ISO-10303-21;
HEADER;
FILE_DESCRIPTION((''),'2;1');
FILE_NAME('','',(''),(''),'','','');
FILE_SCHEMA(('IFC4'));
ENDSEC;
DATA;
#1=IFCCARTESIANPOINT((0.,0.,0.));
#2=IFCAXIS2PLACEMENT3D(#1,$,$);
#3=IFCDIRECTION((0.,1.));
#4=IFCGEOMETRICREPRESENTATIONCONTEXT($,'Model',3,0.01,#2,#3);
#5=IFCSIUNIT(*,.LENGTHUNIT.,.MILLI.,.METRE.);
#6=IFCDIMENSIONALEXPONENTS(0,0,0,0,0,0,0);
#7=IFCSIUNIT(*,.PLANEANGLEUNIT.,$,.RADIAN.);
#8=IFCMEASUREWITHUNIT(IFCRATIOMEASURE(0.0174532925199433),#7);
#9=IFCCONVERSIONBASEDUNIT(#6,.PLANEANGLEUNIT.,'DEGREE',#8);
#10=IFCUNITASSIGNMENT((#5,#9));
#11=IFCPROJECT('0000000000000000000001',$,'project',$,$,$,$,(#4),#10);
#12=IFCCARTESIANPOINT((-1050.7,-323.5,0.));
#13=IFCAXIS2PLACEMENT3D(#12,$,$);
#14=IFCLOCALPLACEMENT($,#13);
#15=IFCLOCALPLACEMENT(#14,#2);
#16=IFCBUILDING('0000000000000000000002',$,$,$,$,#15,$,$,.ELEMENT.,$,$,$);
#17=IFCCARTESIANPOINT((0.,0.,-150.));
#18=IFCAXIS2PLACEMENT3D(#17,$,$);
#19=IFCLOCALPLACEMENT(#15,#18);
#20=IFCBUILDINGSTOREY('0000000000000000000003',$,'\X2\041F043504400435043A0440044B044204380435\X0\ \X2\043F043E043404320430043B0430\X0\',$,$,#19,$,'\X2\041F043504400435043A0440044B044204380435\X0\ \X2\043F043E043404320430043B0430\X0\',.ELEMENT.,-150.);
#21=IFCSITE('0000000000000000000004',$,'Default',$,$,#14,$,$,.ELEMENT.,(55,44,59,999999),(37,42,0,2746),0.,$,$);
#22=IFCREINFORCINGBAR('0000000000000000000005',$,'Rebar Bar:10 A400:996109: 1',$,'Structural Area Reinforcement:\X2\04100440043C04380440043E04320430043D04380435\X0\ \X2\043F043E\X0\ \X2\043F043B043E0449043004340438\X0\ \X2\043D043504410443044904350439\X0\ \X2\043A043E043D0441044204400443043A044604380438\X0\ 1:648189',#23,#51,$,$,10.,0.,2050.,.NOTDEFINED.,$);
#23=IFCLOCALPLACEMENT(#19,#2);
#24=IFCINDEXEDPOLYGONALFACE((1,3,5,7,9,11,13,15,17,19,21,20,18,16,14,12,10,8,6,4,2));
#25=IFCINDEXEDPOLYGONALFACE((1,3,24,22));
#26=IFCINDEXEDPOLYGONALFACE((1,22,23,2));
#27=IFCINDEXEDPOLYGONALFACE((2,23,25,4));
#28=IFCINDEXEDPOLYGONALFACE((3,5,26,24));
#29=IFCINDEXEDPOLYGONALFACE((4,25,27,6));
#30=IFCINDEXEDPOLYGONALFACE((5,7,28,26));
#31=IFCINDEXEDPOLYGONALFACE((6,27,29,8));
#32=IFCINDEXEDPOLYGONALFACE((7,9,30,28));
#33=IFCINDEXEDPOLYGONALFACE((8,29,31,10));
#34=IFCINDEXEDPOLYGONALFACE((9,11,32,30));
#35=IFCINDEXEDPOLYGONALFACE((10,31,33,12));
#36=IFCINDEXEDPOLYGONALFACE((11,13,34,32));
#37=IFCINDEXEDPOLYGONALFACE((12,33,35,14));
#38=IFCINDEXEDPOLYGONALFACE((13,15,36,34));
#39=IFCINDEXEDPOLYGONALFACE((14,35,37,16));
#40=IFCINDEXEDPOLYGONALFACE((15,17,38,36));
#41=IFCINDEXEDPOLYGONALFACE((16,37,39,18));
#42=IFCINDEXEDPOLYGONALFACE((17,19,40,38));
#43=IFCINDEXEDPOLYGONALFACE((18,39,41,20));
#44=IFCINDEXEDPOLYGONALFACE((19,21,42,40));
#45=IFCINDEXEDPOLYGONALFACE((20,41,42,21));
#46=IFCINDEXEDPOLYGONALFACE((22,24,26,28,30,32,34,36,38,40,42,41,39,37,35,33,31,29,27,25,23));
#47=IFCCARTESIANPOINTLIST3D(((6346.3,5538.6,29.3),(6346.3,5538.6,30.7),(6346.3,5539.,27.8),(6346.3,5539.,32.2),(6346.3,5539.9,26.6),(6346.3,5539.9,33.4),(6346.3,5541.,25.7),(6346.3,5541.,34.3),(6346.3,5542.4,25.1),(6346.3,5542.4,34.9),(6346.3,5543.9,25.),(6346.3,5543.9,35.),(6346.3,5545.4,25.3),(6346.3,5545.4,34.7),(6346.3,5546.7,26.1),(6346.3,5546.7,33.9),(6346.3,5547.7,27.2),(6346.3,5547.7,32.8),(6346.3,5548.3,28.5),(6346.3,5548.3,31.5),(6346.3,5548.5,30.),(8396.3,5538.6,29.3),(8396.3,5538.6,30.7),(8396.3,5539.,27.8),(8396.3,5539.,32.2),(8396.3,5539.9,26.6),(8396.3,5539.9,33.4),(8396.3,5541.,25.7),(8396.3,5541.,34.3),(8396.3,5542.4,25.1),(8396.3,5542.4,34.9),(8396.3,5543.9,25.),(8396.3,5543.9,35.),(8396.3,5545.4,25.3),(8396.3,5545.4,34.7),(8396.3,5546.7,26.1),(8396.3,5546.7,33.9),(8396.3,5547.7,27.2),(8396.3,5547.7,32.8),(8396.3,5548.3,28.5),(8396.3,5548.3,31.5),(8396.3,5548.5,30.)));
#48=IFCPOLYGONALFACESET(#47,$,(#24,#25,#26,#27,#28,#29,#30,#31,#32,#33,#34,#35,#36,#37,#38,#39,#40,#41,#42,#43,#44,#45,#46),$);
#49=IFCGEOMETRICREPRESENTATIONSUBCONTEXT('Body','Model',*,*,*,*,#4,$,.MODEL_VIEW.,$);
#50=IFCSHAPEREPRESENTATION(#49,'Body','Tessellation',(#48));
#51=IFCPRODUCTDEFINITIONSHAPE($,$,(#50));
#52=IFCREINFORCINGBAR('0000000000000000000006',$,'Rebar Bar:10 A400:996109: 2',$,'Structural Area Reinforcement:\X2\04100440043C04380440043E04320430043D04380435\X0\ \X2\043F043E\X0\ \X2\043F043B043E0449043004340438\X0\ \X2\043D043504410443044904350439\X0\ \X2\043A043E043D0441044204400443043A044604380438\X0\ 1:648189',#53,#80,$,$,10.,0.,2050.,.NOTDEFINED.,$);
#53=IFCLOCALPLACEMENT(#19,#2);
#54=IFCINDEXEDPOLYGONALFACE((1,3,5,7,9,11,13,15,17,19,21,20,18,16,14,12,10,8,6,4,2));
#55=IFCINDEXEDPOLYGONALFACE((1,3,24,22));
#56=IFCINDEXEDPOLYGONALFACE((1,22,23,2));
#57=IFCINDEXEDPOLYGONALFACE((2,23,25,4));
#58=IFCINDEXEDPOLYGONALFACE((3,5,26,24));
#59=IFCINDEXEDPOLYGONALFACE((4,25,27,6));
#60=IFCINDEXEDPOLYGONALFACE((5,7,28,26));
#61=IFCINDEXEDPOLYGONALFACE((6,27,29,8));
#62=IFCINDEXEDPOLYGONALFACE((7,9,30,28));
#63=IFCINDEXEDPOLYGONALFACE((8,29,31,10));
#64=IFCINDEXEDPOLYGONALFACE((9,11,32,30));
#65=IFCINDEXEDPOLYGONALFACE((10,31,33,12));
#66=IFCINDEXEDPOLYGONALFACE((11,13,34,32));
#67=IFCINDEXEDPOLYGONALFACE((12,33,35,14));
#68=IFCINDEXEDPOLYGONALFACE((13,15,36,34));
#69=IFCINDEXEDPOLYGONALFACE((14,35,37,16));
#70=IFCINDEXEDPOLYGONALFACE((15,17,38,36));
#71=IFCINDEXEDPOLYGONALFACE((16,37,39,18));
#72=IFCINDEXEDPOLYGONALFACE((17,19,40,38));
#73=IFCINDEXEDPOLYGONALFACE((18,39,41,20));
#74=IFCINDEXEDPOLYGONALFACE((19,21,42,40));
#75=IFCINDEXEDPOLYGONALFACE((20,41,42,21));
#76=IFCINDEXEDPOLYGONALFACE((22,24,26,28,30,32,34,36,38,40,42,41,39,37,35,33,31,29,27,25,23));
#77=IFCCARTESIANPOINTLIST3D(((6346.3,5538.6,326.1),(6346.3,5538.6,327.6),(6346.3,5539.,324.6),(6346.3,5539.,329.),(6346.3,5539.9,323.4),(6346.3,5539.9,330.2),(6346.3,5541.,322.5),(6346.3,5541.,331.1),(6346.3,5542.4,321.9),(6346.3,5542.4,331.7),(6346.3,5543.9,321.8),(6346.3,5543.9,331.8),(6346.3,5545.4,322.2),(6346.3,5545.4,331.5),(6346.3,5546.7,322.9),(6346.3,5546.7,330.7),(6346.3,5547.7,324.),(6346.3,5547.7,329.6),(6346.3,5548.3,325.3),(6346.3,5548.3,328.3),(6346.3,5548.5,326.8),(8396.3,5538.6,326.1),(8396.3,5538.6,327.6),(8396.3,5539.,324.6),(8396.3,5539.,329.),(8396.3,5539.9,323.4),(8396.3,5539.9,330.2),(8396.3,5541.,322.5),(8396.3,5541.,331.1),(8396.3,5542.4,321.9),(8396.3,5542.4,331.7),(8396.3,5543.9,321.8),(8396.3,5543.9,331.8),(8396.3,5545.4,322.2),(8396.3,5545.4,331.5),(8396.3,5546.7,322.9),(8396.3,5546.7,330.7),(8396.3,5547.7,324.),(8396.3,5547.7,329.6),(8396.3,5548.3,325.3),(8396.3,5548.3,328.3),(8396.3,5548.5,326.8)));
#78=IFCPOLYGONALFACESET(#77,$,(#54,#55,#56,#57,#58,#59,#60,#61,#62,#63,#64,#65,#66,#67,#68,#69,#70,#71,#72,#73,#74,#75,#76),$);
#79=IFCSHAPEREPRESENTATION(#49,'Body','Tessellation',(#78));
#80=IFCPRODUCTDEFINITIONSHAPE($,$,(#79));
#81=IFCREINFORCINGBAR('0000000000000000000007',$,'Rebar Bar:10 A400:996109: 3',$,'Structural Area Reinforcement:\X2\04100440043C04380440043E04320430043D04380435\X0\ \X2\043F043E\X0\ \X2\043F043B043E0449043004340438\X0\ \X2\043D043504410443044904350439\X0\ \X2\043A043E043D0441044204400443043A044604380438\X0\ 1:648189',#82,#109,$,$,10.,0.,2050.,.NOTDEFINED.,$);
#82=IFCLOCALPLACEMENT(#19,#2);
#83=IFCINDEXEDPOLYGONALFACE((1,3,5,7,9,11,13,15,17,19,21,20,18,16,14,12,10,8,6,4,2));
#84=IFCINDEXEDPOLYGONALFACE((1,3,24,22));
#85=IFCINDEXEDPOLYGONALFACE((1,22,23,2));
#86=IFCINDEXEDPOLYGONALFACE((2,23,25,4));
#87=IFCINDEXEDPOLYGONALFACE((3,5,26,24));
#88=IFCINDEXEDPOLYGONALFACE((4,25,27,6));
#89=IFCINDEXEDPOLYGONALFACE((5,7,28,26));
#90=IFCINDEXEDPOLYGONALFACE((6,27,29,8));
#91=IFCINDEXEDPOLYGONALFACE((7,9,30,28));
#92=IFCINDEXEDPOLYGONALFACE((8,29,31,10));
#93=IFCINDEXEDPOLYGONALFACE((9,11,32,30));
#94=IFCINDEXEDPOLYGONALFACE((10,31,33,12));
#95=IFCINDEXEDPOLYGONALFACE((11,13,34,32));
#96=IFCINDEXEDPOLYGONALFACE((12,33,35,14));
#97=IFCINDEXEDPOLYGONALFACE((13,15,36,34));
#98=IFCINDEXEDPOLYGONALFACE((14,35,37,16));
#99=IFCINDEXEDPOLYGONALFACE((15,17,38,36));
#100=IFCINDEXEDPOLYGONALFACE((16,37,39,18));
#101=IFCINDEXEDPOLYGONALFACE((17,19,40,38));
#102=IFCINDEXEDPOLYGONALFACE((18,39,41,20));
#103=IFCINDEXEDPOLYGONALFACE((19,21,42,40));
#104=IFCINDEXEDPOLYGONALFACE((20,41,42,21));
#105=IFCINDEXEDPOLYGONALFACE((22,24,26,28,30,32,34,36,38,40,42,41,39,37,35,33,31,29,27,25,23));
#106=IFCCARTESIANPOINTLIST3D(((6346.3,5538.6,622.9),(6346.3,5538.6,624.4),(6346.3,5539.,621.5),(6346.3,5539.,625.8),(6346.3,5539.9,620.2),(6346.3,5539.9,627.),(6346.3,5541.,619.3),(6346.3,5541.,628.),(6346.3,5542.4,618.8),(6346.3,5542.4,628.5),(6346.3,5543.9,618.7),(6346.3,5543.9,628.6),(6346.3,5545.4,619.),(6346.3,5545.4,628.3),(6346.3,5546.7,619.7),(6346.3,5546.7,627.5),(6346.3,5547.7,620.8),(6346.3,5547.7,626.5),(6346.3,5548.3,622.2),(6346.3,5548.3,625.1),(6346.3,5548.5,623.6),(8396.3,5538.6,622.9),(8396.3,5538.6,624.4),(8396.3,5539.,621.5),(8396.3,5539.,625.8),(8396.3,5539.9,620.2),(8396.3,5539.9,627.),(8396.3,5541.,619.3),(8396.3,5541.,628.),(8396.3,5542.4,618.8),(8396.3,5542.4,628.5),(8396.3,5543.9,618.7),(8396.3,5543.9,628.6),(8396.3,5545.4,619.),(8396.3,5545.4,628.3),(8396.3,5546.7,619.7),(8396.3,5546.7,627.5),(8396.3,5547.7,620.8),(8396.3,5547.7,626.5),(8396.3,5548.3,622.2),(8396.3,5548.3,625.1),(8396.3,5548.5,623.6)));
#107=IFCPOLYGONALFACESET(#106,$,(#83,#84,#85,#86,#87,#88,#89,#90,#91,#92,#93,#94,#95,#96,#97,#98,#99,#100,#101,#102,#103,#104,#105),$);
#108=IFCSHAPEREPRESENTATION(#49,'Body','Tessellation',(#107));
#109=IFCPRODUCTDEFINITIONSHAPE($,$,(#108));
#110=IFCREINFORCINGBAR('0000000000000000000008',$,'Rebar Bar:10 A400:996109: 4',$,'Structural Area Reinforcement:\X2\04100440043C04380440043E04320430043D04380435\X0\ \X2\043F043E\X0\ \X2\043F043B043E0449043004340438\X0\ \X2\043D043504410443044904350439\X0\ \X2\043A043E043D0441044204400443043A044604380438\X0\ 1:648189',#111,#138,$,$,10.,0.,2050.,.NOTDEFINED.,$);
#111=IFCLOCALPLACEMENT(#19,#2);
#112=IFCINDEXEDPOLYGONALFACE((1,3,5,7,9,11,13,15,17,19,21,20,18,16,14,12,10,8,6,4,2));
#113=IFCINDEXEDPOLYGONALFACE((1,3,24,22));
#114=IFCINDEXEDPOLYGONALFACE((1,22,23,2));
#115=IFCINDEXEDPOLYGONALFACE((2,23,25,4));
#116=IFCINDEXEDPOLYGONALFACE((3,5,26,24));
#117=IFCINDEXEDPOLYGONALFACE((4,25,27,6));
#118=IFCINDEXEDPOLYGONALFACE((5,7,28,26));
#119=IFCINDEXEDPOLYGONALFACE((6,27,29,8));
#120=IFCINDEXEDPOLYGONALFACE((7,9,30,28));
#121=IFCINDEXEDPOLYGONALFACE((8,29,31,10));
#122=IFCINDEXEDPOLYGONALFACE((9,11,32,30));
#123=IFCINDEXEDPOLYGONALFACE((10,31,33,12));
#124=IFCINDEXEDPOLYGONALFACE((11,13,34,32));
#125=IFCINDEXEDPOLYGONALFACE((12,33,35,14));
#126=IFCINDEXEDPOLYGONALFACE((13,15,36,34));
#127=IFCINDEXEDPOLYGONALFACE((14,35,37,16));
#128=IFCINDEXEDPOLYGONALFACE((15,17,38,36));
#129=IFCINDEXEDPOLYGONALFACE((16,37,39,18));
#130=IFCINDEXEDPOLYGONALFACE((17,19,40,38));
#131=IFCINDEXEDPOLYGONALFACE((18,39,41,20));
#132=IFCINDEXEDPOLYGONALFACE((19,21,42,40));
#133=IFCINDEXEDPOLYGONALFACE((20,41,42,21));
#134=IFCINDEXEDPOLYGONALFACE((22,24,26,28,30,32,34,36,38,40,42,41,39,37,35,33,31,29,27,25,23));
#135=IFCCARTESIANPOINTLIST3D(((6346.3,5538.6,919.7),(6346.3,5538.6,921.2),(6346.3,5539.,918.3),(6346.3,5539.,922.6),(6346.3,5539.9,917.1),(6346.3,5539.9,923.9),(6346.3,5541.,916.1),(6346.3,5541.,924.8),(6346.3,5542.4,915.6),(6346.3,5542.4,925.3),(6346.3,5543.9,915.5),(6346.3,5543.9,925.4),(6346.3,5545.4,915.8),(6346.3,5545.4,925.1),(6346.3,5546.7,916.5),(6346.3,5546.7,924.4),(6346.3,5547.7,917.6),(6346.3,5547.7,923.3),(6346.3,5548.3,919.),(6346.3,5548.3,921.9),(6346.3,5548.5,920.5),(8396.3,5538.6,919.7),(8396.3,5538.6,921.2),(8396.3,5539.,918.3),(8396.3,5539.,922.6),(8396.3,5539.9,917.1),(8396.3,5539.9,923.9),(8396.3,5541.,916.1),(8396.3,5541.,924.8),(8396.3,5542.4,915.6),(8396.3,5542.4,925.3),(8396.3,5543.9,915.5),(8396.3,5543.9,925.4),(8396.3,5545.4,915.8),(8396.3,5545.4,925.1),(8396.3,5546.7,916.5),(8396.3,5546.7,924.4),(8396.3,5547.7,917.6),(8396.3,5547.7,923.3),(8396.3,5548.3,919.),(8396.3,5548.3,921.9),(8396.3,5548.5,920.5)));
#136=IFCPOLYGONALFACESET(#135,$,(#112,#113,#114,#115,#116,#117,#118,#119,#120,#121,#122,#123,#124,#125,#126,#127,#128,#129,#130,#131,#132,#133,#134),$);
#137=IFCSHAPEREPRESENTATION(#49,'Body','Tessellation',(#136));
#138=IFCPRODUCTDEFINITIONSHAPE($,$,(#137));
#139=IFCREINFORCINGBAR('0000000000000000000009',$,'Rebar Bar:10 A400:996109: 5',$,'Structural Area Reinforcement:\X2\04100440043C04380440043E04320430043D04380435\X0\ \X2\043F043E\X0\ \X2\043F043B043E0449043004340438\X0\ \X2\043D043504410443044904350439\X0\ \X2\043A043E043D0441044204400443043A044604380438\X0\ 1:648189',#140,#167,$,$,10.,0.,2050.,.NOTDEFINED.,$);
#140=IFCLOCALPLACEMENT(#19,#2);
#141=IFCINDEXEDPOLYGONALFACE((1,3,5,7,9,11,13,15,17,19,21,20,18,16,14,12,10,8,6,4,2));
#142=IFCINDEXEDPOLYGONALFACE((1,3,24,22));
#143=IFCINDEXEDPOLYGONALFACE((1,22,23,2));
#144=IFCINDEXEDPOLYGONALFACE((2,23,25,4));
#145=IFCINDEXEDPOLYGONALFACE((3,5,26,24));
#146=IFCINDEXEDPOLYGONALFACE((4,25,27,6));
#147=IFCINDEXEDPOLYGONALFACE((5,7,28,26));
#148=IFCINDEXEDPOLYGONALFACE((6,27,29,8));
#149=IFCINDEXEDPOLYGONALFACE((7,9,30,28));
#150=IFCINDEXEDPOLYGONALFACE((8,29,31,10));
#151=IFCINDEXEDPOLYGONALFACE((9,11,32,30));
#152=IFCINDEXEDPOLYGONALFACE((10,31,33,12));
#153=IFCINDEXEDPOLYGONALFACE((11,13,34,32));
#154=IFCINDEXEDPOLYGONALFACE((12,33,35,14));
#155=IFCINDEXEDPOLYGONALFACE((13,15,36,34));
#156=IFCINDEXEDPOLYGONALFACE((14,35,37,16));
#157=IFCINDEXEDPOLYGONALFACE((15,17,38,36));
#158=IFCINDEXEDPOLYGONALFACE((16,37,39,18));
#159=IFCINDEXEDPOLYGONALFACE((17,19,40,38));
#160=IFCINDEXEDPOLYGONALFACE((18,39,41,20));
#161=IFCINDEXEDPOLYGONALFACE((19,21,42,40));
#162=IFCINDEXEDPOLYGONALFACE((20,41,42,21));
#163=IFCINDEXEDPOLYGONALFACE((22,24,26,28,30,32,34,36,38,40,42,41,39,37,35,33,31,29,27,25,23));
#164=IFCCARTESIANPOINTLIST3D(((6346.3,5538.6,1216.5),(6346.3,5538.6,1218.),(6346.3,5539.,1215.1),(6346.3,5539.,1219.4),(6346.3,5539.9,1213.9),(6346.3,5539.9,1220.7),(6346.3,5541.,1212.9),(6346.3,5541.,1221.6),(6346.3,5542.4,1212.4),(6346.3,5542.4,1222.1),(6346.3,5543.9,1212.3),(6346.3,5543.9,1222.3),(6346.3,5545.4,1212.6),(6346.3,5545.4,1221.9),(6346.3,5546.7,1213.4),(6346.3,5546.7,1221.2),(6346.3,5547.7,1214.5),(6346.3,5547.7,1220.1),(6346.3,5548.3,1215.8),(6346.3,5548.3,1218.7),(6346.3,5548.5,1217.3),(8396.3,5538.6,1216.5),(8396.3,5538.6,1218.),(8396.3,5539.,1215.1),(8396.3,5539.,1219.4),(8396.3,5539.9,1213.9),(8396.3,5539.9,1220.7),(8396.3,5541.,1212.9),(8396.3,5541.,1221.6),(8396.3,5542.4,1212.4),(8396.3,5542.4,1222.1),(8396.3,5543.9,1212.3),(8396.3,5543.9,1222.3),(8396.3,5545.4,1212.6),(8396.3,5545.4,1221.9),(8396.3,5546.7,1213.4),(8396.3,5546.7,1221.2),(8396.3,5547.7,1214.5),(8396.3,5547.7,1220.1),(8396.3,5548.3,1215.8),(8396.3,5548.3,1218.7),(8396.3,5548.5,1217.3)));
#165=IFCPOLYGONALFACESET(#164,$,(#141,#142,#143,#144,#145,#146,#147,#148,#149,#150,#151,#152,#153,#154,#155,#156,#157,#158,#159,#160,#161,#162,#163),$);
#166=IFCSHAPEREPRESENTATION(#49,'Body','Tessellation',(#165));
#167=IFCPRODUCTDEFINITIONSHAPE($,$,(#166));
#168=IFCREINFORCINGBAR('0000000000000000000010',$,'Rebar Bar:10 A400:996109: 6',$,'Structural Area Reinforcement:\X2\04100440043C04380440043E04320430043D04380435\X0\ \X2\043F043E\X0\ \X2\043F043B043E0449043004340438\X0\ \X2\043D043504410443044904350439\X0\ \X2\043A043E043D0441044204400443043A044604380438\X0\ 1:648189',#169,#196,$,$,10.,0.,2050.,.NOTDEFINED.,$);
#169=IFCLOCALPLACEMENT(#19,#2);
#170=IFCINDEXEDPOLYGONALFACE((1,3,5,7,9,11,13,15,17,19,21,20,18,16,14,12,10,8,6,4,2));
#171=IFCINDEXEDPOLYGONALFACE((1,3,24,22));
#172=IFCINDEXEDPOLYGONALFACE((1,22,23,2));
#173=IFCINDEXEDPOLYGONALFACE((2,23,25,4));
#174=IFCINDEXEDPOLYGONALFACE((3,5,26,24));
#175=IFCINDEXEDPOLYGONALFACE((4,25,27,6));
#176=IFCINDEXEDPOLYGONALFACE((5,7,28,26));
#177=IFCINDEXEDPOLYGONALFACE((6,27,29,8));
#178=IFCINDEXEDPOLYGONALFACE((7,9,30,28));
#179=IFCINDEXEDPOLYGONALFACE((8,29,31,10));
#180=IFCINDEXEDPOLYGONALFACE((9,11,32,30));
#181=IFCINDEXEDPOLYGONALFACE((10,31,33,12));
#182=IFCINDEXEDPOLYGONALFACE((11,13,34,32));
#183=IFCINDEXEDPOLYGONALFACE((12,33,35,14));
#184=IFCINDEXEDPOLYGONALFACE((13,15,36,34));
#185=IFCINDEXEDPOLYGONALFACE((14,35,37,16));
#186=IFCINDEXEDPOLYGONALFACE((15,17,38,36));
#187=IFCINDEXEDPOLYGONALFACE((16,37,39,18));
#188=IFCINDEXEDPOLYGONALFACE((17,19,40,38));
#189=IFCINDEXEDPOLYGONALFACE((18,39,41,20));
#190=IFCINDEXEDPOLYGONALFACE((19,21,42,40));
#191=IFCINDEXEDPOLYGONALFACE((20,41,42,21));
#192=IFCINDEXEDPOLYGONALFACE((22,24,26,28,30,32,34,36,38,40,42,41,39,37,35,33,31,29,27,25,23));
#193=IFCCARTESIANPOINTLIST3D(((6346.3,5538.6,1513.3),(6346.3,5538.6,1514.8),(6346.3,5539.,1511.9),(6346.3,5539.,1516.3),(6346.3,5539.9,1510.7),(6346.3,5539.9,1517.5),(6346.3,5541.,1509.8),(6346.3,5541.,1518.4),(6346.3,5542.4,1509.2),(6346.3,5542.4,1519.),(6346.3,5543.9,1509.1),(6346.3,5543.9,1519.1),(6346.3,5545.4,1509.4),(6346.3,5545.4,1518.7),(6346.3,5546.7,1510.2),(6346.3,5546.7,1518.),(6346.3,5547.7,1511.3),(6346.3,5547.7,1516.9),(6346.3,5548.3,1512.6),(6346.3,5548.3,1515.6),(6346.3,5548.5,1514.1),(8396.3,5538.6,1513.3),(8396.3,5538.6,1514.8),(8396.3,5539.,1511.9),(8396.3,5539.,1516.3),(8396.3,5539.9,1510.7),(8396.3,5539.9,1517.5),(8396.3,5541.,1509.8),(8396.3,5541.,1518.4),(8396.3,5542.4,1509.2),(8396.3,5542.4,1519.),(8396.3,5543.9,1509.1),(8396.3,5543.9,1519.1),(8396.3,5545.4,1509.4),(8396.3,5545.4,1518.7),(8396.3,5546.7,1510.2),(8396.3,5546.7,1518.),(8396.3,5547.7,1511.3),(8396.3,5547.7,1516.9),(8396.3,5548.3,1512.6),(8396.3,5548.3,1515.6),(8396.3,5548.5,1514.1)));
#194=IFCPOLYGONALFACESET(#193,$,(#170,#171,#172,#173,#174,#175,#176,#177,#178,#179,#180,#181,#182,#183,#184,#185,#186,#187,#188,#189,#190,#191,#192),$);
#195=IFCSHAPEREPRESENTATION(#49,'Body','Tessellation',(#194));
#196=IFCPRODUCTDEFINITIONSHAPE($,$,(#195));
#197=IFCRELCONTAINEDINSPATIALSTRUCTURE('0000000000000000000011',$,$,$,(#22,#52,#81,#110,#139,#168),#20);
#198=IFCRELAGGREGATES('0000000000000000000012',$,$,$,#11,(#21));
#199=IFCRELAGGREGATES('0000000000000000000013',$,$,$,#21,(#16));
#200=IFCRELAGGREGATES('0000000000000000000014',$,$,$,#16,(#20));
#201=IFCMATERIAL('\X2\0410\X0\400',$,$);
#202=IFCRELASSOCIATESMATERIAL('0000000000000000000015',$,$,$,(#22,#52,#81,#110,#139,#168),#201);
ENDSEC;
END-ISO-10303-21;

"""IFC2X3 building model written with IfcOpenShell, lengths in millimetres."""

from ifc_helpers import new_model, entity, si_unit, converted_unit, direction, frame, origin, place, context, subcontext, project, spatial, material, element, save


model = new_model("IFC2X3")

# Units and contexts
model_context = context("Model", 3, precision=0.01, world=origin(), true_north=direction((0.0, 1.0)))
body_context = subcontext(model_context, "Body", "Model", "MODEL_VIEW")
ifc_project = project(units=[si_unit("LENGTHUNIT", "METRE", prefix="MILLI"), converted_unit("PLANEANGLEUNIT", "DEGREE", entity("IfcRatioMeasure", 0.0174532925199433), si_unit("PLANEANGLEUNIT", "RADIAN"), dimensions=[0, 0, 0, 0, 0, 0, 0])], contexts=[model_context])

# Site, building, storey
site_placement = place(None, frame((-1050.7, -323.5, 0.0)))
site = spatial("IfcSite", under=ifc_project, at=site_placement, Name="Default", CompositionType="ELEMENT", RefLatitude=(55, 44, 59, 999999), RefLongitude=(37, 42, 0, 2746), RefElevation=0.0)
building_placement = place(site_placement, origin())
building = spatial("IfcBuilding", under=site, at=building_placement, CompositionType="ELEMENT")
storey_placement = place(building_placement, frame((0.0, 0.0, -150.0)))
storey = spatial("IfcBuildingStorey", under=building, at=storey_placement, Name="Перекрытие подвала", LongName="Перекрытие подвала", CompositionType="ELEMENT", Elevation=-150.0)

# Reinforcing bars
ifc_material = material(Name="А400")
reinforcing_bar_1_placement = place(storey_placement, origin())
element("IfcReinforcingBar", 1, at=reinforcing_bar_1_placement, inside=storey, material=ifc_material, Name="Rebar Bar:10 A400:996109: 1", ObjectType="Structural Area Reinforcement:Армирование по площади несущей конструкции 1:648189", BarLength=2050.0, BarRole="NOTDEFINED", CrossSectionArea=0.0, NominalDiameter=10.0, context=body_context, shape_type="AdvancedSweptSolid", body=[
    entity("IfcSweptDiskSolid", entity("IfcCompositeCurve", [entity("IfcCompositeCurveSegment", "CONTINUOUS", True, entity("IfcPolyline", [entity("IfcCartesianPoint", [6346.3, 5543.5, 30.0]), entity("IfcCartesianPoint", [8396.3, 5543.5, 30.0])]))], False), 5.0, None, 0.0, 1.0),
])
reinforcing_bar_2_placement = place(storey_placement, origin())
element("IfcReinforcingBar", 2, at=reinforcing_bar_2_placement, inside=storey, material=ifc_material, Name="Rebar Bar:10 A400:996109: 2", ObjectType="Structural Area Reinforcement:Армирование по площади несущей конструкции 1:648189", BarLength=2050.0, BarRole="NOTDEFINED", CrossSectionArea=0.0, NominalDiameter=10.0, context=body_context, shape_type="AdvancedSweptSolid", body=[
    entity("IfcSweptDiskSolid", entity("IfcCompositeCurve", [entity("IfcCompositeCurveSegment", "CONTINUOUS", True, entity("IfcPolyline", [entity("IfcCartesianPoint", [6346.3, 5543.5, 326.8]), entity("IfcCartesianPoint", [8396.3, 5543.5, 326.8])]))], False), 5.0, None, 0.0, 1.0),
])
reinforcing_bar_3_placement = place(storey_placement, origin())
element("IfcReinforcingBar", 3, at=reinforcing_bar_3_placement, inside=storey, material=ifc_material, Name="Rebar Bar:10 A400:996109: 3", ObjectType="Structural Area Reinforcement:Армирование по площади несущей конструкции 1:648189", BarLength=2050.0, BarRole="NOTDEFINED", CrossSectionArea=0.0, NominalDiameter=10.0, context=body_context, shape_type="AdvancedSweptSolid", body=[
    entity("IfcSweptDiskSolid", entity("IfcCompositeCurve", [entity("IfcCompositeCurveSegment", "CONTINUOUS", True, entity("IfcPolyline", [entity("IfcCartesianPoint", [6346.3, 5543.5, 623.6]), entity("IfcCartesianPoint", [8396.3, 5543.5, 623.6])]))], False), 5.0, None, 0.0, 1.0),
])
reinforcing_bar_4_placement = place(storey_placement, origin())
element("IfcReinforcingBar", 4, at=reinforcing_bar_4_placement, inside=storey, material=ifc_material, Name="Rebar Bar:10 A400:996109: 4", ObjectType="Structural Area Reinforcement:Армирование по площади несущей конструкции 1:648189", BarLength=2050.0, BarRole="NOTDEFINED", CrossSectionArea=0.0, NominalDiameter=10.0, context=body_context, shape_type="AdvancedSweptSolid", body=[
    entity("IfcSweptDiskSolid", entity("IfcCompositeCurve", [entity("IfcCompositeCurveSegment", "CONTINUOUS", True, entity("IfcPolyline", [entity("IfcCartesianPoint", [6346.3, 5543.5, 920.5]), entity("IfcCartesianPoint", [8396.3, 5543.5, 920.5])]))], False), 5.0, None, 0.0, 1.0),
])
reinforcing_bar_5_placement = place(storey_placement, origin())
element("IfcReinforcingBar", 5, at=reinforcing_bar_5_placement, inside=storey, material=ifc_material, Name="Rebar Bar:10 A400:996109: 5", ObjectType="Structural Area Reinforcement:Армирование по площади несущей конструкции 1:648189", BarLength=2050.0, BarRole="NOTDEFINED", CrossSectionArea=0.0, NominalDiameter=10.0, context=body_context, shape_type="AdvancedSweptSolid", body=[
    entity("IfcSweptDiskSolid", entity("IfcCompositeCurve", [entity("IfcCompositeCurveSegment", "CONTINUOUS", True, entity("IfcPolyline", [entity("IfcCartesianPoint", [6346.3, 5543.5, 1217.3]), entity("IfcCartesianPoint", [8396.3, 5543.5, 1217.3])]))], False), 5.0, None, 0.0, 1.0),
])
reinforcing_bar_6_placement = place(storey_placement, origin())
element("IfcReinforcingBar", 6, at=reinforcing_bar_6_placement, inside=storey, material=ifc_material, Name="Rebar Bar:10 A400:996109: 6", ObjectType="Structural Area Reinforcement:Армирование по площади несущей конструкции 1:648189", BarLength=2050.0, BarRole="NOTDEFINED", CrossSectionArea=0.0, NominalDiameter=10.0, context=body_context, shape_type="AdvancedSweptSolid", body=[
    entity("IfcSweptDiskSolid", entity("IfcCompositeCurve", [entity("IfcCompositeCurveSegment", "CONTINUOUS", True, entity("IfcPolyline", [entity("IfcCartesianPoint", [6346.3, 5543.5, 1514.1]), entity("IfcCartesianPoint", [8396.3, 5543.5, 1514.1])]))], False), 5.0, None, 0.0, 1.0),
])

save(model, "model.ifc")
